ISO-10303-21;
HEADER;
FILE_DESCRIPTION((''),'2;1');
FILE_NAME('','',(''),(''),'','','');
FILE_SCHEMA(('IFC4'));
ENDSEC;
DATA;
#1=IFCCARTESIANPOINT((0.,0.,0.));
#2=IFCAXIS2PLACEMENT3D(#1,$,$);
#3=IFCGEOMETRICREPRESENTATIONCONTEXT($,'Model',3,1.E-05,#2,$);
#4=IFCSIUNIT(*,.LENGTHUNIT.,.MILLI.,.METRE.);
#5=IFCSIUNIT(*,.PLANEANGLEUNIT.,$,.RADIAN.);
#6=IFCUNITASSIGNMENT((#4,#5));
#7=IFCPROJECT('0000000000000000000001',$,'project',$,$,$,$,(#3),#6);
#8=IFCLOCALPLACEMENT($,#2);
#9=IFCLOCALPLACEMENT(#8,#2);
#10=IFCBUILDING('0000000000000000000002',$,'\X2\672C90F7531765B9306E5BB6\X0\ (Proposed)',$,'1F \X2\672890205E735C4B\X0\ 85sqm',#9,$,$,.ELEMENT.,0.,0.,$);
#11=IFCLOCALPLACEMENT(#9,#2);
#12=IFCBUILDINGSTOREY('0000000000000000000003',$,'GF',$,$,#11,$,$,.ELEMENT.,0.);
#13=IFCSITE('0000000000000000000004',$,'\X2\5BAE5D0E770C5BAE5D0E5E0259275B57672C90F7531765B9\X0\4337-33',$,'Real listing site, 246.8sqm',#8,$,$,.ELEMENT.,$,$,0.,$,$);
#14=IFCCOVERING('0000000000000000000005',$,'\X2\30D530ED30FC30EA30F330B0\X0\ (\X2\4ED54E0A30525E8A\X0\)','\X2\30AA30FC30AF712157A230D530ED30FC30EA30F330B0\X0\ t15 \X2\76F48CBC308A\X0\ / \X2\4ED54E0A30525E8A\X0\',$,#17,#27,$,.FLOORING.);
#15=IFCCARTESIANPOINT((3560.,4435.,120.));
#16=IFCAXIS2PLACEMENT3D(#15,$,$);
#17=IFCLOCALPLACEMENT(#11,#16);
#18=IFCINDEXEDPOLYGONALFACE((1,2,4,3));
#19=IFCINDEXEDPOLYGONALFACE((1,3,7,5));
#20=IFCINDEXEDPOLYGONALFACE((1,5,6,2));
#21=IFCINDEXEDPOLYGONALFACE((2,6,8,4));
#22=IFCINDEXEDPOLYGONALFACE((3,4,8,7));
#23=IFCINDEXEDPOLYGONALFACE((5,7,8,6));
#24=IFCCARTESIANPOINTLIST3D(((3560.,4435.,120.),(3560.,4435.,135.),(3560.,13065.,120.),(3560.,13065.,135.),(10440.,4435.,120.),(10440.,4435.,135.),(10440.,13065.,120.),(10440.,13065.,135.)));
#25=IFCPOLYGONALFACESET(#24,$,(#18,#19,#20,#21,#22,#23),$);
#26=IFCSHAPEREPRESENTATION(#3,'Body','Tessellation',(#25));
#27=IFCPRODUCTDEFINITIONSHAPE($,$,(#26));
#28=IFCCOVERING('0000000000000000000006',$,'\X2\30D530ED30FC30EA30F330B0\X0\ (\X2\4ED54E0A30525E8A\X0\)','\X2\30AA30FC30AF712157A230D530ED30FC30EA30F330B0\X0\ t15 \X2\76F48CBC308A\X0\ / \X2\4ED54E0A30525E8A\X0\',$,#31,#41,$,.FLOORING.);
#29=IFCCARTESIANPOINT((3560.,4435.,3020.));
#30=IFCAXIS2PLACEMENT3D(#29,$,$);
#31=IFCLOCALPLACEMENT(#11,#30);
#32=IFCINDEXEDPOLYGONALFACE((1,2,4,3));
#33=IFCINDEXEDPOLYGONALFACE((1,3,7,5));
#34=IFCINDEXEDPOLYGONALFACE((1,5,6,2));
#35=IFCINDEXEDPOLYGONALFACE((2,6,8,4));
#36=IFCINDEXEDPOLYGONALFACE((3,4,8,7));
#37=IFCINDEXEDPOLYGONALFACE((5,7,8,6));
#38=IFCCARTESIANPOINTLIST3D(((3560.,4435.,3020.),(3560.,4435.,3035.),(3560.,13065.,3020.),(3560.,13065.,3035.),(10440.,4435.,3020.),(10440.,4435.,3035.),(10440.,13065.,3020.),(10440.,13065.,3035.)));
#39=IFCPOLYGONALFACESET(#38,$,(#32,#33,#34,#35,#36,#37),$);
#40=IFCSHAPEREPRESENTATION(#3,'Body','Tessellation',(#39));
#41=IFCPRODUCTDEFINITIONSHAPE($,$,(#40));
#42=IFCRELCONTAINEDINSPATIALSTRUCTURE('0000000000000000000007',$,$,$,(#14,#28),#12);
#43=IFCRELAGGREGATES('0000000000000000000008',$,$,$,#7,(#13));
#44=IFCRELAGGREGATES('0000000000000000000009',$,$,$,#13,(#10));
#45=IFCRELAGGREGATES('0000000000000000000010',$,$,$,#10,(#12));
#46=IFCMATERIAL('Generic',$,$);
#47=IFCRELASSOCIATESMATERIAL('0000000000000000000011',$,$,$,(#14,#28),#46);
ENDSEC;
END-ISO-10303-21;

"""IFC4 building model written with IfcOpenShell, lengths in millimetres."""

from ifc_helpers import new_model, si_unit, frame, frame_2d, origin, place, context, project, spatial, rectangle, extrude, material, element, save


model = new_model("IFC4")

# Units and contexts
model_context = context("Model", 3, precision=1e-05, world=origin())
ifc_project = project(units=[si_unit("LENGTHUNIT", "METRE", prefix="MILLI"), si_unit("PLANEANGLEUNIT", "RADIAN")], contexts=[model_context])

# Site, building, storey
site_placement = place(None, origin())
site = spatial("IfcSite", under=ifc_project, at=site_placement, Name="宮崎県宮崎市大字本郷北方4337-33", ObjectType="Real listing site, 246.8sqm", CompositionType="ELEMENT", RefElevation=0.0)
building_placement = place(site_placement, origin())
building = spatial("IfcBuilding", under=site, at=building_placement, Name="本郷北方の家 (Proposed)", ObjectType="1F 木造平屋 85sqm", CompositionType="ELEMENT", ElevationOfRefHeight=0.0, ElevationOfTerrain=0.0)
storey_placement = place(building_placement, origin())
storey = spatial("IfcBuildingStorey", under=building, at=storey_placement, Name="GF", CompositionType="ELEMENT", Elevation=0.0)

# Shared definitions
ifc_material_1 = material(Name="Generic")

# Coverings
covering_1_placement = place(storey_placement, frame((3560.0, 4435.0, 120.0)))
element("IfcCovering", 1, at=covering_1_placement, inside=storey, material=ifc_material_1, Name="フローリング (仕上げ床)", Description="オーク無垢フローリング t15 直貼り / 仕上げ床", PredefinedType="FLOORING", context=model_context, shape_type="SweptSolid", body=[
    extrude(rectangle(XDim=6880.0, YDim=8630.0, at=frame_2d((3440.0, 4315.0))), frame((3560.0, 4435.0, 120.0)), (0.0, 0.0, 1.0), 15.0),
])
covering_2_placement = place(storey_placement, frame((3560.0, 4435.0, 3020.0)))
element("IfcCovering", 2, at=covering_2_placement, inside=storey, material=ifc_material_1, Name="フローリング (仕上げ床)", Description="オーク無垢フローリング t15 直貼り / 仕上げ床", PredefinedType="FLOORING", context=model_context, shape_type="SweptSolid", body=[
    extrude(rectangle(XDim=6880.0, YDim=8630.0, at=frame_2d((3440.0, 4315.0))), frame((3560.0, 4435.0, 3020.0)), (0.0, 0.0, 1.0), 15.0),
])

save(model, "model.ifc")
